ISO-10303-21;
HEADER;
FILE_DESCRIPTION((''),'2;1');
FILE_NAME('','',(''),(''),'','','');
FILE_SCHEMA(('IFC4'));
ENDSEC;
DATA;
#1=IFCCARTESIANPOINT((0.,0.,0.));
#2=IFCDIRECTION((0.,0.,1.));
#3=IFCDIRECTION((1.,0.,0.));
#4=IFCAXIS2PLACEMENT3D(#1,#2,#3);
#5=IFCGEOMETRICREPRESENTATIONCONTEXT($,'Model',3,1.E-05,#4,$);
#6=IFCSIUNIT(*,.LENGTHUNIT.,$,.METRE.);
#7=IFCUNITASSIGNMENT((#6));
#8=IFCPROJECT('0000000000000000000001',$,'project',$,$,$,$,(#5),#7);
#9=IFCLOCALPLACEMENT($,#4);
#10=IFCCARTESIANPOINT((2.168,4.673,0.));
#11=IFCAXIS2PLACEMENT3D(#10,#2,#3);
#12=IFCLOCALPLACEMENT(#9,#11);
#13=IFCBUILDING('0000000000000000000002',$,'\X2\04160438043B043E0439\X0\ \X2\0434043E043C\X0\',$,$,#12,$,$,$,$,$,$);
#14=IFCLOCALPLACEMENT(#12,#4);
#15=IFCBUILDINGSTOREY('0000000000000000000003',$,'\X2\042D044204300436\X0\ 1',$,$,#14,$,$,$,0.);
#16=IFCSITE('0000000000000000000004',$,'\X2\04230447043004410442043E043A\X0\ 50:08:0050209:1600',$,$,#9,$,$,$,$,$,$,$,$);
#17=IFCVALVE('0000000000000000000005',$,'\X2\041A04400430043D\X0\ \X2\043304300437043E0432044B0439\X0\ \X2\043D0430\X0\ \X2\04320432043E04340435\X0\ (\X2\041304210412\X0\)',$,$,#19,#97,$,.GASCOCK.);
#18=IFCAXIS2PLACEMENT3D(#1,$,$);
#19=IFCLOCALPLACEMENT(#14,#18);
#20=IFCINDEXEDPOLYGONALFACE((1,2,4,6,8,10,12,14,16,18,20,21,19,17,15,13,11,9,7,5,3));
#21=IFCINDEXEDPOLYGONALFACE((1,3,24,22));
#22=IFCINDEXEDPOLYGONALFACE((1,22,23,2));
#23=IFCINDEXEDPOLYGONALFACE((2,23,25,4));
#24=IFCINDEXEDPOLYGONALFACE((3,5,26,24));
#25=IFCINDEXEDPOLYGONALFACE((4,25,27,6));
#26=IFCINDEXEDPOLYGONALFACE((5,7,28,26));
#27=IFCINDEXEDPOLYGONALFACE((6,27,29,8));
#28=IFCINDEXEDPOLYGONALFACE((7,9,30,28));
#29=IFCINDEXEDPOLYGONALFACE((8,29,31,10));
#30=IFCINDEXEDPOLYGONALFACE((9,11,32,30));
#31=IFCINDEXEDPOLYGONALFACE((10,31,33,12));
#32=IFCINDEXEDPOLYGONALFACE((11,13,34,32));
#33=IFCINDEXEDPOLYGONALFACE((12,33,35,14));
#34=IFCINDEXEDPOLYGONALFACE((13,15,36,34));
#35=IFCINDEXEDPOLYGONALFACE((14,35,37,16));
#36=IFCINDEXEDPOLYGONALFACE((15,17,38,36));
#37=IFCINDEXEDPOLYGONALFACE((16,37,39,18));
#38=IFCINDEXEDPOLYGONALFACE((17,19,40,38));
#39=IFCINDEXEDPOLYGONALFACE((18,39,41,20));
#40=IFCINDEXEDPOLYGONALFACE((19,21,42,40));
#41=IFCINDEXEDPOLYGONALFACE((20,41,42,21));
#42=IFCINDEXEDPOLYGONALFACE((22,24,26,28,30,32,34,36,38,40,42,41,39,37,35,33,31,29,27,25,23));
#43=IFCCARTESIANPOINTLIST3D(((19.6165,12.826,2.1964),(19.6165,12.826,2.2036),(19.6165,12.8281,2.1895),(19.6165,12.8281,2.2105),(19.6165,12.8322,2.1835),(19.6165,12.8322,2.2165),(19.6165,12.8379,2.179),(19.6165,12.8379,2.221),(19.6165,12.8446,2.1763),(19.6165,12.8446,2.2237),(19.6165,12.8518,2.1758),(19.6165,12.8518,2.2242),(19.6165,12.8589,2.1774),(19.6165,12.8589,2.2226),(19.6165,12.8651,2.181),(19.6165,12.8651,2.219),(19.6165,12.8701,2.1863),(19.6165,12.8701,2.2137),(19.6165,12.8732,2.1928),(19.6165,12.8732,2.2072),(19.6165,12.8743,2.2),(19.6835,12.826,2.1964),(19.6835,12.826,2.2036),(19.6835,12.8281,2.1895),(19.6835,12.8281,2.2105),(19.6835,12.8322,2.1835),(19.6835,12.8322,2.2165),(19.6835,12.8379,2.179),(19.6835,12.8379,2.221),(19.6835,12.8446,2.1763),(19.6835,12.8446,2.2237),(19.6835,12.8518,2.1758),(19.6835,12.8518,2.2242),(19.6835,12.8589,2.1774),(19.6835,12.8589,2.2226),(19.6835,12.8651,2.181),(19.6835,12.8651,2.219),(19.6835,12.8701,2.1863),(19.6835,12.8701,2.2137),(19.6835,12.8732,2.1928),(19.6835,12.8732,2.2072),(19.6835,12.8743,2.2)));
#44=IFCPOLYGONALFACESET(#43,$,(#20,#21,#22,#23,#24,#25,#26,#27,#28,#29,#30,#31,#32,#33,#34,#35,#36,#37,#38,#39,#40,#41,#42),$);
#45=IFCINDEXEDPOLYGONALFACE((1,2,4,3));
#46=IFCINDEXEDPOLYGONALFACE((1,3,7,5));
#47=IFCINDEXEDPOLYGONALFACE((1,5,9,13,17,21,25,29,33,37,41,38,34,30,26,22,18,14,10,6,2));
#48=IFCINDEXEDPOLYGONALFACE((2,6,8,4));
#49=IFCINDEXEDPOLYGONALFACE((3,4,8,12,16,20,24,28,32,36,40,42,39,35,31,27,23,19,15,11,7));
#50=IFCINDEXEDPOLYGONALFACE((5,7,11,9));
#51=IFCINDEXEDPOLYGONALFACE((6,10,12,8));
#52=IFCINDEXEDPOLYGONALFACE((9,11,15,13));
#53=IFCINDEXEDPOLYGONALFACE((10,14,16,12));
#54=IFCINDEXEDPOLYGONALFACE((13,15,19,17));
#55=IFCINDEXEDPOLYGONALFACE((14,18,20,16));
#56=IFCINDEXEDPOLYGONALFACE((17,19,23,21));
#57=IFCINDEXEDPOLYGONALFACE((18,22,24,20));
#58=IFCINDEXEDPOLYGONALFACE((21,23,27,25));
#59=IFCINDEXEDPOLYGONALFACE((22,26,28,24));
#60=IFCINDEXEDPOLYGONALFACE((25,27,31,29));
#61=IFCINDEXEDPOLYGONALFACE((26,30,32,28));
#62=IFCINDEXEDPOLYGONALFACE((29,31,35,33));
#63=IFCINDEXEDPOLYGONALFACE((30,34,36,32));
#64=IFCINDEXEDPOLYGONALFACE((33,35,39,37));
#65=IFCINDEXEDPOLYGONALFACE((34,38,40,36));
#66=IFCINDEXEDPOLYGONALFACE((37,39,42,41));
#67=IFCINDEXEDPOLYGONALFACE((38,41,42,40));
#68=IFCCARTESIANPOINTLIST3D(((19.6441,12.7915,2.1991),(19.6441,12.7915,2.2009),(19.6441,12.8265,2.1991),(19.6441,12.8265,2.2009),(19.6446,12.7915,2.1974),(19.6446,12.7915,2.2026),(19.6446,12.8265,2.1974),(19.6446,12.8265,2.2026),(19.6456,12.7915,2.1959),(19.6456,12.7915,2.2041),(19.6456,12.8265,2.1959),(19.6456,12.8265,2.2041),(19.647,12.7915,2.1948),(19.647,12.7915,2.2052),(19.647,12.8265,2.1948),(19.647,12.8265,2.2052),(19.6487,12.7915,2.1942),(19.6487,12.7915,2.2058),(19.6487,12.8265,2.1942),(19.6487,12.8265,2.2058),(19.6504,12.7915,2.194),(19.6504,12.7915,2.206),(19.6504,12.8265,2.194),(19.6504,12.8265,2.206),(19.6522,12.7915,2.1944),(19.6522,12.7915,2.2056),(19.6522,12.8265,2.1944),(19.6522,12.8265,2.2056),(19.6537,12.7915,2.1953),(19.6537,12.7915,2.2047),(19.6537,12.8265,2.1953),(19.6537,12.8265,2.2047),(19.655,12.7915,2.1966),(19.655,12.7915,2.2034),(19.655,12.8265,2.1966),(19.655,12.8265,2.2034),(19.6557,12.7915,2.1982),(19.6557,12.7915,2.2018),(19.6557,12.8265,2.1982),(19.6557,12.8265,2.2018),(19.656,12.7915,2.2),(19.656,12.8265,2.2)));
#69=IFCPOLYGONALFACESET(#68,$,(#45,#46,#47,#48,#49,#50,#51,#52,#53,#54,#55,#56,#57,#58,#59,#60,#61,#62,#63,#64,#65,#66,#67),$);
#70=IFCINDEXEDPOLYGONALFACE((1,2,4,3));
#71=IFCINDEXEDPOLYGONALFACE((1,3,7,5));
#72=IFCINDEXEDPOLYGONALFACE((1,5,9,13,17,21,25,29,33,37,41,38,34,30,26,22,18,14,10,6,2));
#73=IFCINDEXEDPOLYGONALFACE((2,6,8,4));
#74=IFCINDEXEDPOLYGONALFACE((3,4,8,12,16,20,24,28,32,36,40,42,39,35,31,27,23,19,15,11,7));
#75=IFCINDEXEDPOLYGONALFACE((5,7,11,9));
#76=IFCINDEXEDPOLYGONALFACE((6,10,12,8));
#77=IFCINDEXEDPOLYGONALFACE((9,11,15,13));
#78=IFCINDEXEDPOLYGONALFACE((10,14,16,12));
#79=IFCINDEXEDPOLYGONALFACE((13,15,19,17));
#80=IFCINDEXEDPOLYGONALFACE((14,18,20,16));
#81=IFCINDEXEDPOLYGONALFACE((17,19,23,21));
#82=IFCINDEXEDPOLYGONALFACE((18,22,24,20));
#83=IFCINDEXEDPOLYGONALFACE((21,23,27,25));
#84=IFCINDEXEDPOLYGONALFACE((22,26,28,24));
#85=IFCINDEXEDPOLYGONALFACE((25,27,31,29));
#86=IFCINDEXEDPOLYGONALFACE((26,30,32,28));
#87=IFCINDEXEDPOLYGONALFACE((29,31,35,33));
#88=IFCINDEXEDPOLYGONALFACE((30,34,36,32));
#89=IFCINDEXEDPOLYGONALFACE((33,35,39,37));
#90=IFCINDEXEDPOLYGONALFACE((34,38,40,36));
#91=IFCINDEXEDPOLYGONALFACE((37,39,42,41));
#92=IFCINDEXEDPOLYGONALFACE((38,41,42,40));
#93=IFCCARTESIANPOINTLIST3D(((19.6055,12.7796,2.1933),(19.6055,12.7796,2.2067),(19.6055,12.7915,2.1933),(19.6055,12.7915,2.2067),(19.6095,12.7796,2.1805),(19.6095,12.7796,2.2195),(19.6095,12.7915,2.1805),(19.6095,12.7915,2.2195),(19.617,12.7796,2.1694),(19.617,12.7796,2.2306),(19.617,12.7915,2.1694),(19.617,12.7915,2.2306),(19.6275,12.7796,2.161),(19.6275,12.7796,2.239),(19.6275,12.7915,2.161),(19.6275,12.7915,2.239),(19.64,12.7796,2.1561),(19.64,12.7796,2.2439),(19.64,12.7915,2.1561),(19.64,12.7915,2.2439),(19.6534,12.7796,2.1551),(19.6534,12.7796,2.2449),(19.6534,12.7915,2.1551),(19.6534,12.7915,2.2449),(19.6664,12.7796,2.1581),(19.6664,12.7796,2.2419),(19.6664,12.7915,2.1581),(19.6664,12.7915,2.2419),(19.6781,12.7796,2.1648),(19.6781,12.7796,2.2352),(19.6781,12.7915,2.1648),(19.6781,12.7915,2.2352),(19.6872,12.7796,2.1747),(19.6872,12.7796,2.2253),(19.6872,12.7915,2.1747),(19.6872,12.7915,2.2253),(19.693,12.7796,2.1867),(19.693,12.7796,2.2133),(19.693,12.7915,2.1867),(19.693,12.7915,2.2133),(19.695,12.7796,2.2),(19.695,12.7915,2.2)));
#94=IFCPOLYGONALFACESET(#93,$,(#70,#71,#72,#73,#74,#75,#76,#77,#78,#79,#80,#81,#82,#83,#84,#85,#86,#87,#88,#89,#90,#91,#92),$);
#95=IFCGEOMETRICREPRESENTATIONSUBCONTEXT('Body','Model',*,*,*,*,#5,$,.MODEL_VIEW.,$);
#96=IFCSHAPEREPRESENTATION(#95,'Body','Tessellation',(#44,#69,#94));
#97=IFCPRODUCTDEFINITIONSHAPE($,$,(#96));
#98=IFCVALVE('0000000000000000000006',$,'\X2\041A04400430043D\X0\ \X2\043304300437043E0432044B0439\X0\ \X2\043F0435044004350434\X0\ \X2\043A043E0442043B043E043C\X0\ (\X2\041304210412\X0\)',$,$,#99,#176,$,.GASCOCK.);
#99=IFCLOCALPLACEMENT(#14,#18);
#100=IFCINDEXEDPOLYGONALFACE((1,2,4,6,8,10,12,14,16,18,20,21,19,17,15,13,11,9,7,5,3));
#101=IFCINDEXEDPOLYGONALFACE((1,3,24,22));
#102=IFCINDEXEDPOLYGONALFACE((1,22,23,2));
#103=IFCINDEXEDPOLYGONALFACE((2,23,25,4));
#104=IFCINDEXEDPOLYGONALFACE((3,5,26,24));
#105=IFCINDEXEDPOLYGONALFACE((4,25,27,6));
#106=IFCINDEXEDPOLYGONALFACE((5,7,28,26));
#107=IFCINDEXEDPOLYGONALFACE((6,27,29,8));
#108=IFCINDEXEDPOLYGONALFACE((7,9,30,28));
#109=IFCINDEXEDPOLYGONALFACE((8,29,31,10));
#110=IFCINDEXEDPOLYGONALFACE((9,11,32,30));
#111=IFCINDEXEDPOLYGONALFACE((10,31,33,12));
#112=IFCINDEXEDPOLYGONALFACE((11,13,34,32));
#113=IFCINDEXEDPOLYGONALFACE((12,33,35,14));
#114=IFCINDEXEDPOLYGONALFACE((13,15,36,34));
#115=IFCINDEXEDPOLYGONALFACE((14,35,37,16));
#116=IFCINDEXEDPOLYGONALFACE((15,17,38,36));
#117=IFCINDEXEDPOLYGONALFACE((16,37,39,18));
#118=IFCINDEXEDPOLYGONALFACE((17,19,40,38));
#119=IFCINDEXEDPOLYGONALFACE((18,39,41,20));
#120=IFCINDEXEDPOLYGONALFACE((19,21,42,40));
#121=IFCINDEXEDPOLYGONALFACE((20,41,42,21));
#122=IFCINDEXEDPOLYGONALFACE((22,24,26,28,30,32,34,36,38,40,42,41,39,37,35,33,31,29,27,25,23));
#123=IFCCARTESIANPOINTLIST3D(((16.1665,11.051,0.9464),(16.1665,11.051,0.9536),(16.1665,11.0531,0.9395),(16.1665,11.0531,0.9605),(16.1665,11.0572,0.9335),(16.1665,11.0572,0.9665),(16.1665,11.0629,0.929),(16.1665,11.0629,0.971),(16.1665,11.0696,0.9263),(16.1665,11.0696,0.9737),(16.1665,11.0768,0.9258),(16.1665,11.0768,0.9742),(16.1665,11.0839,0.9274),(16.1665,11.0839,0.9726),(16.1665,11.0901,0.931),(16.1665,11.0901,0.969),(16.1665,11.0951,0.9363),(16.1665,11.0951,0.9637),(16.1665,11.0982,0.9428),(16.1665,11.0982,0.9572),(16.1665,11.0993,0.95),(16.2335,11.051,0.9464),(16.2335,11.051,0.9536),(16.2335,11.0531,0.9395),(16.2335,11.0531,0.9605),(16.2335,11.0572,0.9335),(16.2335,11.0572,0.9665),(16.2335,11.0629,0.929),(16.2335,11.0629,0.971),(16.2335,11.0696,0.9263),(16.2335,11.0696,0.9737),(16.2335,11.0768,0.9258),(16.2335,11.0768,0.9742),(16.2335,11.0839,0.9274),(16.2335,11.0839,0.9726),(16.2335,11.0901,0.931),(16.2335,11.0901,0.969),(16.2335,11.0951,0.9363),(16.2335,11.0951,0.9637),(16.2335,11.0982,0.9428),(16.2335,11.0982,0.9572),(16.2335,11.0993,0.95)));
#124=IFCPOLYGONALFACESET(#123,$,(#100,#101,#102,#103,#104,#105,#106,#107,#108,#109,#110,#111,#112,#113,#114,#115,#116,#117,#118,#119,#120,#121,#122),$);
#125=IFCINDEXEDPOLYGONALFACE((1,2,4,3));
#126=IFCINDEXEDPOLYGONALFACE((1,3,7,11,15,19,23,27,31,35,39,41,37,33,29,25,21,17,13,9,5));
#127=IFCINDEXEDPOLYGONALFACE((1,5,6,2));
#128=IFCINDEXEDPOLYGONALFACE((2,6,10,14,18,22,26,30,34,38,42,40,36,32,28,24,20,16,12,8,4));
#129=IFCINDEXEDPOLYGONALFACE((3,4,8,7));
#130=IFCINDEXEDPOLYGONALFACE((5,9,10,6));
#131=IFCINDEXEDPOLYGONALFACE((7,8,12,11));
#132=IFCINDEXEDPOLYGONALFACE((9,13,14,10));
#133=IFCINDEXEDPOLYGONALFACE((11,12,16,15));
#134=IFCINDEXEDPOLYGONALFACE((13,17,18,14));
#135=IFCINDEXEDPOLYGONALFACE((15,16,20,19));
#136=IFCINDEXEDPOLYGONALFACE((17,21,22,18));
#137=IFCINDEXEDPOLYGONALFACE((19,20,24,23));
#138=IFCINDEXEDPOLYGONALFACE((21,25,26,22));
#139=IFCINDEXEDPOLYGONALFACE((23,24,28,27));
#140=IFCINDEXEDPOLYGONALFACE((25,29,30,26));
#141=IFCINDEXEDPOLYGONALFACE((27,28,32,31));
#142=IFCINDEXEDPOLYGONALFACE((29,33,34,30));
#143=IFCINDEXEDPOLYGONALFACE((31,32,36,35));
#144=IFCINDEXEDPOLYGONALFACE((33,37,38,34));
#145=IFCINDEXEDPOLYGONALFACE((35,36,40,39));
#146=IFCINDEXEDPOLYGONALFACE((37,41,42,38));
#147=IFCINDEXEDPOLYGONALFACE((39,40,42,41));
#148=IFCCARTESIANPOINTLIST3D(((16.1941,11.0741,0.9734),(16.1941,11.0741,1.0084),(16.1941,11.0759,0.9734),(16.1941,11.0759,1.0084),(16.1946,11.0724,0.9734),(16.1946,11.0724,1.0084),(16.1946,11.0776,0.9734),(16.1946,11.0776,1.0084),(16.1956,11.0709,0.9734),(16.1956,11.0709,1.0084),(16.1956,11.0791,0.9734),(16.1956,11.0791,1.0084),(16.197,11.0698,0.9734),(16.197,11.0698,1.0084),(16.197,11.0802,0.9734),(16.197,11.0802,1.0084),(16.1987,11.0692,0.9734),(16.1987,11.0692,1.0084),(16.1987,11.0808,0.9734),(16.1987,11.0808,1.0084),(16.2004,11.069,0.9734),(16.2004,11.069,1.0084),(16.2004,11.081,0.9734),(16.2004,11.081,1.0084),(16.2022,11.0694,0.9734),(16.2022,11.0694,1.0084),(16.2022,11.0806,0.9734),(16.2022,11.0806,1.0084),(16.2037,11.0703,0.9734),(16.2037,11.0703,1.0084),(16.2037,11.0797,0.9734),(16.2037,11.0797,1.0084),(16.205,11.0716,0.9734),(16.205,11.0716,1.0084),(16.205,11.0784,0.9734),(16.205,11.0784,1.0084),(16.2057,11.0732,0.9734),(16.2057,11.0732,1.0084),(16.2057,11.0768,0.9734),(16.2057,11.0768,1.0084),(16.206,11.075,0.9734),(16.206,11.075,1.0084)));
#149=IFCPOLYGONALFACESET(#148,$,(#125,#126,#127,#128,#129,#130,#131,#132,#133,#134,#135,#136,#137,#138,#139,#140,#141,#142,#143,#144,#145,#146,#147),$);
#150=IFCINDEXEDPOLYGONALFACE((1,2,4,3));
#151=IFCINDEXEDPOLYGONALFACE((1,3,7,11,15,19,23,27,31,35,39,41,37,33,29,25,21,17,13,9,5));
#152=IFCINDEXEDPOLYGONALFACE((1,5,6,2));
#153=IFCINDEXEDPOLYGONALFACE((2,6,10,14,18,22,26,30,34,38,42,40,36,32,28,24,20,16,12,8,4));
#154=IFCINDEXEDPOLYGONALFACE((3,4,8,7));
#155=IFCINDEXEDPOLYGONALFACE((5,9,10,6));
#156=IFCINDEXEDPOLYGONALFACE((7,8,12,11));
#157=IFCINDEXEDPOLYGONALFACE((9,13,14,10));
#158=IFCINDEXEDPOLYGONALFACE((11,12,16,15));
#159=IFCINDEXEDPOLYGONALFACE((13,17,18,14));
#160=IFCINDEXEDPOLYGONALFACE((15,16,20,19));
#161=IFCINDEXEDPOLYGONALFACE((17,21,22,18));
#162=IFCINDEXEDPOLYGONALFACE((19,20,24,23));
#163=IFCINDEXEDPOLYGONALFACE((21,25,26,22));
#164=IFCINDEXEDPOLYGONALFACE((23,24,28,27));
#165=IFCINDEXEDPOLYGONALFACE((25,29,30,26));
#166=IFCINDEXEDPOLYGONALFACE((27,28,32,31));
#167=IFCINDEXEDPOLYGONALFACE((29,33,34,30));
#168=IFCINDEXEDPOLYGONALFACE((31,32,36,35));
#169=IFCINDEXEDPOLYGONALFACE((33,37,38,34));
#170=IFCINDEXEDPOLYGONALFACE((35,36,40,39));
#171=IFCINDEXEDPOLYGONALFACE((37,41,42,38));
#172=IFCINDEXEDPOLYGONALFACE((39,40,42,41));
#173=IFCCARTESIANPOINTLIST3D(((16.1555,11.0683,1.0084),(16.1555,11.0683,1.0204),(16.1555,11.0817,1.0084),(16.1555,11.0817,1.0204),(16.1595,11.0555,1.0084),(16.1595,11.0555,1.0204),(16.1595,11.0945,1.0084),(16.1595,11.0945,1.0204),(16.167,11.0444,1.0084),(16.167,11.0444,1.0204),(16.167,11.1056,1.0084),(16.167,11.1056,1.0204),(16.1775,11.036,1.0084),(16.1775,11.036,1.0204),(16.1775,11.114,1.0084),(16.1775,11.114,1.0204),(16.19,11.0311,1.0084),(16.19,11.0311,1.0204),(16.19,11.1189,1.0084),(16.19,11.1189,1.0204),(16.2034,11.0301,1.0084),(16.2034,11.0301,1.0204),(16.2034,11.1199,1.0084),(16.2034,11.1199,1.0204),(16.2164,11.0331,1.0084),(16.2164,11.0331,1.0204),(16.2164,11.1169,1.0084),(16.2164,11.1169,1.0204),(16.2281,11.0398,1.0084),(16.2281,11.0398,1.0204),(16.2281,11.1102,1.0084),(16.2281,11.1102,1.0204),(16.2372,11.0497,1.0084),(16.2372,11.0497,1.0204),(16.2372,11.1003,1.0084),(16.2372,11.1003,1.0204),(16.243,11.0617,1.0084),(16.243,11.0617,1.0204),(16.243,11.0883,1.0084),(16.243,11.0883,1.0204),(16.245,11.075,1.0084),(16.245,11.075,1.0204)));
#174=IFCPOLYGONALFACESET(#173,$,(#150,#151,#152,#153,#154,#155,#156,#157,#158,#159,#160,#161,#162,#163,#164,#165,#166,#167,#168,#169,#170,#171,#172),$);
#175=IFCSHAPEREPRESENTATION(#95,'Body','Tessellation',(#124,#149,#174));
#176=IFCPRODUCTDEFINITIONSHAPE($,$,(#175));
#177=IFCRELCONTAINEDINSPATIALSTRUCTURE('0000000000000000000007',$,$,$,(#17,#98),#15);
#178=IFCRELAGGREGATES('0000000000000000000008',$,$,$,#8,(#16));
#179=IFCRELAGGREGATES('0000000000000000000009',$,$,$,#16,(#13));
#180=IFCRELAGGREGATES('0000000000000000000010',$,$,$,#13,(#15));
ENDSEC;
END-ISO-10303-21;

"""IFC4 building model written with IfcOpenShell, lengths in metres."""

from ifc_helpers import new_model, si_unit, frame, origin_with_axes, origin_2d, place, context, subcontext, project, spatial, circle, extrude, element, save


model = new_model("IFC4")

# Units and contexts
model_context = context("Model", 3, precision=1e-05, world=origin_with_axes())
body_context = subcontext(model_context, "Body", "Model", "MODEL_VIEW")
ifc_project = project(units=[si_unit("LENGTHUNIT", "METRE")], contexts=[model_context])

# Site, building, storey
site_placement = place(None, origin_with_axes())
site = spatial("IfcSite", under=ifc_project, at=site_placement, Name="Участок 50:08:0050209:1600")
building_placement = place(site_placement, frame((2.168, 4.673, 0.0), z_axis=(0.0, 0.0, 1.0), x_axis=(1.0, 0.0, 0.0)))
building = spatial("IfcBuilding", under=site, at=building_placement, Name="Жилой дом")
storey_placement = place(building_placement, origin_with_axes())
storey = spatial("IfcBuildingStorey", under=building, at=storey_placement, Name="Этаж 1", Elevation=0.0)

# Valves
valve_1_placement = place(storey_placement, origin_with_axes())
element("IfcValve", 1, at=valve_1_placement, inside=storey, Name="Кран газовый на вводе (ГСВ)", PredefinedType="GASCOCK", context=body_context, shape_type="SweptSolid", body=[
    extrude(circle(Radius=0.0243, at=origin_2d()), frame((19.6165, 12.85, 2.2), z_axis=(1.0, 0.0, 0.0), x_axis=(0.0, 1.0, 0.0)), (0.0, 0.0, 1.0), 0.067),
    extrude(circle(Radius=0.006, at=origin_2d()), frame((19.65, 12.8265, 2.2), z_axis=(0.0, -1.0, 0.0), x_axis=(1.0, 0.0, 0.0)), (0.0, 0.0, 1.0), 0.035),
    extrude(circle(Radius=0.045, at=origin_2d()), frame((19.65, 12.7915, 2.2), z_axis=(0.0, -1.0, 0.0), x_axis=(1.0, 0.0, 0.0)), (0.0, 0.0, 1.0), 0.012),
])
valve_2_placement = place(storey_placement, origin_with_axes())
element("IfcValve", 2, at=valve_2_placement, inside=storey, Name="Кран газовый перед котлом (ГСВ)", PredefinedType="GASCOCK", context=body_context, shape_type="SweptSolid", body=[
    extrude(circle(Radius=0.0243, at=origin_2d()), frame((16.1665, 11.075, 0.95), z_axis=(1.0, 0.0, 0.0), x_axis=(0.0, 1.0, 0.0)), (0.0, 0.0, 1.0), 0.067),
    extrude(circle(Radius=0.006, at=origin_2d()), frame((16.2, 11.075, 0.9734), z_axis=(0.0, 0.0, 1.0), x_axis=(1.0, 0.0, 0.0)), (0.0, 0.0, 1.0), 0.035),
    extrude(circle(Radius=0.045, at=origin_2d()), frame((16.2, 11.075, 1.0084), z_axis=(0.0, 0.0, 1.0), x_axis=(1.0, 0.0, 0.0)), (0.0, 0.0, 1.0), 0.012),
])

save(model, "model.ifc")
